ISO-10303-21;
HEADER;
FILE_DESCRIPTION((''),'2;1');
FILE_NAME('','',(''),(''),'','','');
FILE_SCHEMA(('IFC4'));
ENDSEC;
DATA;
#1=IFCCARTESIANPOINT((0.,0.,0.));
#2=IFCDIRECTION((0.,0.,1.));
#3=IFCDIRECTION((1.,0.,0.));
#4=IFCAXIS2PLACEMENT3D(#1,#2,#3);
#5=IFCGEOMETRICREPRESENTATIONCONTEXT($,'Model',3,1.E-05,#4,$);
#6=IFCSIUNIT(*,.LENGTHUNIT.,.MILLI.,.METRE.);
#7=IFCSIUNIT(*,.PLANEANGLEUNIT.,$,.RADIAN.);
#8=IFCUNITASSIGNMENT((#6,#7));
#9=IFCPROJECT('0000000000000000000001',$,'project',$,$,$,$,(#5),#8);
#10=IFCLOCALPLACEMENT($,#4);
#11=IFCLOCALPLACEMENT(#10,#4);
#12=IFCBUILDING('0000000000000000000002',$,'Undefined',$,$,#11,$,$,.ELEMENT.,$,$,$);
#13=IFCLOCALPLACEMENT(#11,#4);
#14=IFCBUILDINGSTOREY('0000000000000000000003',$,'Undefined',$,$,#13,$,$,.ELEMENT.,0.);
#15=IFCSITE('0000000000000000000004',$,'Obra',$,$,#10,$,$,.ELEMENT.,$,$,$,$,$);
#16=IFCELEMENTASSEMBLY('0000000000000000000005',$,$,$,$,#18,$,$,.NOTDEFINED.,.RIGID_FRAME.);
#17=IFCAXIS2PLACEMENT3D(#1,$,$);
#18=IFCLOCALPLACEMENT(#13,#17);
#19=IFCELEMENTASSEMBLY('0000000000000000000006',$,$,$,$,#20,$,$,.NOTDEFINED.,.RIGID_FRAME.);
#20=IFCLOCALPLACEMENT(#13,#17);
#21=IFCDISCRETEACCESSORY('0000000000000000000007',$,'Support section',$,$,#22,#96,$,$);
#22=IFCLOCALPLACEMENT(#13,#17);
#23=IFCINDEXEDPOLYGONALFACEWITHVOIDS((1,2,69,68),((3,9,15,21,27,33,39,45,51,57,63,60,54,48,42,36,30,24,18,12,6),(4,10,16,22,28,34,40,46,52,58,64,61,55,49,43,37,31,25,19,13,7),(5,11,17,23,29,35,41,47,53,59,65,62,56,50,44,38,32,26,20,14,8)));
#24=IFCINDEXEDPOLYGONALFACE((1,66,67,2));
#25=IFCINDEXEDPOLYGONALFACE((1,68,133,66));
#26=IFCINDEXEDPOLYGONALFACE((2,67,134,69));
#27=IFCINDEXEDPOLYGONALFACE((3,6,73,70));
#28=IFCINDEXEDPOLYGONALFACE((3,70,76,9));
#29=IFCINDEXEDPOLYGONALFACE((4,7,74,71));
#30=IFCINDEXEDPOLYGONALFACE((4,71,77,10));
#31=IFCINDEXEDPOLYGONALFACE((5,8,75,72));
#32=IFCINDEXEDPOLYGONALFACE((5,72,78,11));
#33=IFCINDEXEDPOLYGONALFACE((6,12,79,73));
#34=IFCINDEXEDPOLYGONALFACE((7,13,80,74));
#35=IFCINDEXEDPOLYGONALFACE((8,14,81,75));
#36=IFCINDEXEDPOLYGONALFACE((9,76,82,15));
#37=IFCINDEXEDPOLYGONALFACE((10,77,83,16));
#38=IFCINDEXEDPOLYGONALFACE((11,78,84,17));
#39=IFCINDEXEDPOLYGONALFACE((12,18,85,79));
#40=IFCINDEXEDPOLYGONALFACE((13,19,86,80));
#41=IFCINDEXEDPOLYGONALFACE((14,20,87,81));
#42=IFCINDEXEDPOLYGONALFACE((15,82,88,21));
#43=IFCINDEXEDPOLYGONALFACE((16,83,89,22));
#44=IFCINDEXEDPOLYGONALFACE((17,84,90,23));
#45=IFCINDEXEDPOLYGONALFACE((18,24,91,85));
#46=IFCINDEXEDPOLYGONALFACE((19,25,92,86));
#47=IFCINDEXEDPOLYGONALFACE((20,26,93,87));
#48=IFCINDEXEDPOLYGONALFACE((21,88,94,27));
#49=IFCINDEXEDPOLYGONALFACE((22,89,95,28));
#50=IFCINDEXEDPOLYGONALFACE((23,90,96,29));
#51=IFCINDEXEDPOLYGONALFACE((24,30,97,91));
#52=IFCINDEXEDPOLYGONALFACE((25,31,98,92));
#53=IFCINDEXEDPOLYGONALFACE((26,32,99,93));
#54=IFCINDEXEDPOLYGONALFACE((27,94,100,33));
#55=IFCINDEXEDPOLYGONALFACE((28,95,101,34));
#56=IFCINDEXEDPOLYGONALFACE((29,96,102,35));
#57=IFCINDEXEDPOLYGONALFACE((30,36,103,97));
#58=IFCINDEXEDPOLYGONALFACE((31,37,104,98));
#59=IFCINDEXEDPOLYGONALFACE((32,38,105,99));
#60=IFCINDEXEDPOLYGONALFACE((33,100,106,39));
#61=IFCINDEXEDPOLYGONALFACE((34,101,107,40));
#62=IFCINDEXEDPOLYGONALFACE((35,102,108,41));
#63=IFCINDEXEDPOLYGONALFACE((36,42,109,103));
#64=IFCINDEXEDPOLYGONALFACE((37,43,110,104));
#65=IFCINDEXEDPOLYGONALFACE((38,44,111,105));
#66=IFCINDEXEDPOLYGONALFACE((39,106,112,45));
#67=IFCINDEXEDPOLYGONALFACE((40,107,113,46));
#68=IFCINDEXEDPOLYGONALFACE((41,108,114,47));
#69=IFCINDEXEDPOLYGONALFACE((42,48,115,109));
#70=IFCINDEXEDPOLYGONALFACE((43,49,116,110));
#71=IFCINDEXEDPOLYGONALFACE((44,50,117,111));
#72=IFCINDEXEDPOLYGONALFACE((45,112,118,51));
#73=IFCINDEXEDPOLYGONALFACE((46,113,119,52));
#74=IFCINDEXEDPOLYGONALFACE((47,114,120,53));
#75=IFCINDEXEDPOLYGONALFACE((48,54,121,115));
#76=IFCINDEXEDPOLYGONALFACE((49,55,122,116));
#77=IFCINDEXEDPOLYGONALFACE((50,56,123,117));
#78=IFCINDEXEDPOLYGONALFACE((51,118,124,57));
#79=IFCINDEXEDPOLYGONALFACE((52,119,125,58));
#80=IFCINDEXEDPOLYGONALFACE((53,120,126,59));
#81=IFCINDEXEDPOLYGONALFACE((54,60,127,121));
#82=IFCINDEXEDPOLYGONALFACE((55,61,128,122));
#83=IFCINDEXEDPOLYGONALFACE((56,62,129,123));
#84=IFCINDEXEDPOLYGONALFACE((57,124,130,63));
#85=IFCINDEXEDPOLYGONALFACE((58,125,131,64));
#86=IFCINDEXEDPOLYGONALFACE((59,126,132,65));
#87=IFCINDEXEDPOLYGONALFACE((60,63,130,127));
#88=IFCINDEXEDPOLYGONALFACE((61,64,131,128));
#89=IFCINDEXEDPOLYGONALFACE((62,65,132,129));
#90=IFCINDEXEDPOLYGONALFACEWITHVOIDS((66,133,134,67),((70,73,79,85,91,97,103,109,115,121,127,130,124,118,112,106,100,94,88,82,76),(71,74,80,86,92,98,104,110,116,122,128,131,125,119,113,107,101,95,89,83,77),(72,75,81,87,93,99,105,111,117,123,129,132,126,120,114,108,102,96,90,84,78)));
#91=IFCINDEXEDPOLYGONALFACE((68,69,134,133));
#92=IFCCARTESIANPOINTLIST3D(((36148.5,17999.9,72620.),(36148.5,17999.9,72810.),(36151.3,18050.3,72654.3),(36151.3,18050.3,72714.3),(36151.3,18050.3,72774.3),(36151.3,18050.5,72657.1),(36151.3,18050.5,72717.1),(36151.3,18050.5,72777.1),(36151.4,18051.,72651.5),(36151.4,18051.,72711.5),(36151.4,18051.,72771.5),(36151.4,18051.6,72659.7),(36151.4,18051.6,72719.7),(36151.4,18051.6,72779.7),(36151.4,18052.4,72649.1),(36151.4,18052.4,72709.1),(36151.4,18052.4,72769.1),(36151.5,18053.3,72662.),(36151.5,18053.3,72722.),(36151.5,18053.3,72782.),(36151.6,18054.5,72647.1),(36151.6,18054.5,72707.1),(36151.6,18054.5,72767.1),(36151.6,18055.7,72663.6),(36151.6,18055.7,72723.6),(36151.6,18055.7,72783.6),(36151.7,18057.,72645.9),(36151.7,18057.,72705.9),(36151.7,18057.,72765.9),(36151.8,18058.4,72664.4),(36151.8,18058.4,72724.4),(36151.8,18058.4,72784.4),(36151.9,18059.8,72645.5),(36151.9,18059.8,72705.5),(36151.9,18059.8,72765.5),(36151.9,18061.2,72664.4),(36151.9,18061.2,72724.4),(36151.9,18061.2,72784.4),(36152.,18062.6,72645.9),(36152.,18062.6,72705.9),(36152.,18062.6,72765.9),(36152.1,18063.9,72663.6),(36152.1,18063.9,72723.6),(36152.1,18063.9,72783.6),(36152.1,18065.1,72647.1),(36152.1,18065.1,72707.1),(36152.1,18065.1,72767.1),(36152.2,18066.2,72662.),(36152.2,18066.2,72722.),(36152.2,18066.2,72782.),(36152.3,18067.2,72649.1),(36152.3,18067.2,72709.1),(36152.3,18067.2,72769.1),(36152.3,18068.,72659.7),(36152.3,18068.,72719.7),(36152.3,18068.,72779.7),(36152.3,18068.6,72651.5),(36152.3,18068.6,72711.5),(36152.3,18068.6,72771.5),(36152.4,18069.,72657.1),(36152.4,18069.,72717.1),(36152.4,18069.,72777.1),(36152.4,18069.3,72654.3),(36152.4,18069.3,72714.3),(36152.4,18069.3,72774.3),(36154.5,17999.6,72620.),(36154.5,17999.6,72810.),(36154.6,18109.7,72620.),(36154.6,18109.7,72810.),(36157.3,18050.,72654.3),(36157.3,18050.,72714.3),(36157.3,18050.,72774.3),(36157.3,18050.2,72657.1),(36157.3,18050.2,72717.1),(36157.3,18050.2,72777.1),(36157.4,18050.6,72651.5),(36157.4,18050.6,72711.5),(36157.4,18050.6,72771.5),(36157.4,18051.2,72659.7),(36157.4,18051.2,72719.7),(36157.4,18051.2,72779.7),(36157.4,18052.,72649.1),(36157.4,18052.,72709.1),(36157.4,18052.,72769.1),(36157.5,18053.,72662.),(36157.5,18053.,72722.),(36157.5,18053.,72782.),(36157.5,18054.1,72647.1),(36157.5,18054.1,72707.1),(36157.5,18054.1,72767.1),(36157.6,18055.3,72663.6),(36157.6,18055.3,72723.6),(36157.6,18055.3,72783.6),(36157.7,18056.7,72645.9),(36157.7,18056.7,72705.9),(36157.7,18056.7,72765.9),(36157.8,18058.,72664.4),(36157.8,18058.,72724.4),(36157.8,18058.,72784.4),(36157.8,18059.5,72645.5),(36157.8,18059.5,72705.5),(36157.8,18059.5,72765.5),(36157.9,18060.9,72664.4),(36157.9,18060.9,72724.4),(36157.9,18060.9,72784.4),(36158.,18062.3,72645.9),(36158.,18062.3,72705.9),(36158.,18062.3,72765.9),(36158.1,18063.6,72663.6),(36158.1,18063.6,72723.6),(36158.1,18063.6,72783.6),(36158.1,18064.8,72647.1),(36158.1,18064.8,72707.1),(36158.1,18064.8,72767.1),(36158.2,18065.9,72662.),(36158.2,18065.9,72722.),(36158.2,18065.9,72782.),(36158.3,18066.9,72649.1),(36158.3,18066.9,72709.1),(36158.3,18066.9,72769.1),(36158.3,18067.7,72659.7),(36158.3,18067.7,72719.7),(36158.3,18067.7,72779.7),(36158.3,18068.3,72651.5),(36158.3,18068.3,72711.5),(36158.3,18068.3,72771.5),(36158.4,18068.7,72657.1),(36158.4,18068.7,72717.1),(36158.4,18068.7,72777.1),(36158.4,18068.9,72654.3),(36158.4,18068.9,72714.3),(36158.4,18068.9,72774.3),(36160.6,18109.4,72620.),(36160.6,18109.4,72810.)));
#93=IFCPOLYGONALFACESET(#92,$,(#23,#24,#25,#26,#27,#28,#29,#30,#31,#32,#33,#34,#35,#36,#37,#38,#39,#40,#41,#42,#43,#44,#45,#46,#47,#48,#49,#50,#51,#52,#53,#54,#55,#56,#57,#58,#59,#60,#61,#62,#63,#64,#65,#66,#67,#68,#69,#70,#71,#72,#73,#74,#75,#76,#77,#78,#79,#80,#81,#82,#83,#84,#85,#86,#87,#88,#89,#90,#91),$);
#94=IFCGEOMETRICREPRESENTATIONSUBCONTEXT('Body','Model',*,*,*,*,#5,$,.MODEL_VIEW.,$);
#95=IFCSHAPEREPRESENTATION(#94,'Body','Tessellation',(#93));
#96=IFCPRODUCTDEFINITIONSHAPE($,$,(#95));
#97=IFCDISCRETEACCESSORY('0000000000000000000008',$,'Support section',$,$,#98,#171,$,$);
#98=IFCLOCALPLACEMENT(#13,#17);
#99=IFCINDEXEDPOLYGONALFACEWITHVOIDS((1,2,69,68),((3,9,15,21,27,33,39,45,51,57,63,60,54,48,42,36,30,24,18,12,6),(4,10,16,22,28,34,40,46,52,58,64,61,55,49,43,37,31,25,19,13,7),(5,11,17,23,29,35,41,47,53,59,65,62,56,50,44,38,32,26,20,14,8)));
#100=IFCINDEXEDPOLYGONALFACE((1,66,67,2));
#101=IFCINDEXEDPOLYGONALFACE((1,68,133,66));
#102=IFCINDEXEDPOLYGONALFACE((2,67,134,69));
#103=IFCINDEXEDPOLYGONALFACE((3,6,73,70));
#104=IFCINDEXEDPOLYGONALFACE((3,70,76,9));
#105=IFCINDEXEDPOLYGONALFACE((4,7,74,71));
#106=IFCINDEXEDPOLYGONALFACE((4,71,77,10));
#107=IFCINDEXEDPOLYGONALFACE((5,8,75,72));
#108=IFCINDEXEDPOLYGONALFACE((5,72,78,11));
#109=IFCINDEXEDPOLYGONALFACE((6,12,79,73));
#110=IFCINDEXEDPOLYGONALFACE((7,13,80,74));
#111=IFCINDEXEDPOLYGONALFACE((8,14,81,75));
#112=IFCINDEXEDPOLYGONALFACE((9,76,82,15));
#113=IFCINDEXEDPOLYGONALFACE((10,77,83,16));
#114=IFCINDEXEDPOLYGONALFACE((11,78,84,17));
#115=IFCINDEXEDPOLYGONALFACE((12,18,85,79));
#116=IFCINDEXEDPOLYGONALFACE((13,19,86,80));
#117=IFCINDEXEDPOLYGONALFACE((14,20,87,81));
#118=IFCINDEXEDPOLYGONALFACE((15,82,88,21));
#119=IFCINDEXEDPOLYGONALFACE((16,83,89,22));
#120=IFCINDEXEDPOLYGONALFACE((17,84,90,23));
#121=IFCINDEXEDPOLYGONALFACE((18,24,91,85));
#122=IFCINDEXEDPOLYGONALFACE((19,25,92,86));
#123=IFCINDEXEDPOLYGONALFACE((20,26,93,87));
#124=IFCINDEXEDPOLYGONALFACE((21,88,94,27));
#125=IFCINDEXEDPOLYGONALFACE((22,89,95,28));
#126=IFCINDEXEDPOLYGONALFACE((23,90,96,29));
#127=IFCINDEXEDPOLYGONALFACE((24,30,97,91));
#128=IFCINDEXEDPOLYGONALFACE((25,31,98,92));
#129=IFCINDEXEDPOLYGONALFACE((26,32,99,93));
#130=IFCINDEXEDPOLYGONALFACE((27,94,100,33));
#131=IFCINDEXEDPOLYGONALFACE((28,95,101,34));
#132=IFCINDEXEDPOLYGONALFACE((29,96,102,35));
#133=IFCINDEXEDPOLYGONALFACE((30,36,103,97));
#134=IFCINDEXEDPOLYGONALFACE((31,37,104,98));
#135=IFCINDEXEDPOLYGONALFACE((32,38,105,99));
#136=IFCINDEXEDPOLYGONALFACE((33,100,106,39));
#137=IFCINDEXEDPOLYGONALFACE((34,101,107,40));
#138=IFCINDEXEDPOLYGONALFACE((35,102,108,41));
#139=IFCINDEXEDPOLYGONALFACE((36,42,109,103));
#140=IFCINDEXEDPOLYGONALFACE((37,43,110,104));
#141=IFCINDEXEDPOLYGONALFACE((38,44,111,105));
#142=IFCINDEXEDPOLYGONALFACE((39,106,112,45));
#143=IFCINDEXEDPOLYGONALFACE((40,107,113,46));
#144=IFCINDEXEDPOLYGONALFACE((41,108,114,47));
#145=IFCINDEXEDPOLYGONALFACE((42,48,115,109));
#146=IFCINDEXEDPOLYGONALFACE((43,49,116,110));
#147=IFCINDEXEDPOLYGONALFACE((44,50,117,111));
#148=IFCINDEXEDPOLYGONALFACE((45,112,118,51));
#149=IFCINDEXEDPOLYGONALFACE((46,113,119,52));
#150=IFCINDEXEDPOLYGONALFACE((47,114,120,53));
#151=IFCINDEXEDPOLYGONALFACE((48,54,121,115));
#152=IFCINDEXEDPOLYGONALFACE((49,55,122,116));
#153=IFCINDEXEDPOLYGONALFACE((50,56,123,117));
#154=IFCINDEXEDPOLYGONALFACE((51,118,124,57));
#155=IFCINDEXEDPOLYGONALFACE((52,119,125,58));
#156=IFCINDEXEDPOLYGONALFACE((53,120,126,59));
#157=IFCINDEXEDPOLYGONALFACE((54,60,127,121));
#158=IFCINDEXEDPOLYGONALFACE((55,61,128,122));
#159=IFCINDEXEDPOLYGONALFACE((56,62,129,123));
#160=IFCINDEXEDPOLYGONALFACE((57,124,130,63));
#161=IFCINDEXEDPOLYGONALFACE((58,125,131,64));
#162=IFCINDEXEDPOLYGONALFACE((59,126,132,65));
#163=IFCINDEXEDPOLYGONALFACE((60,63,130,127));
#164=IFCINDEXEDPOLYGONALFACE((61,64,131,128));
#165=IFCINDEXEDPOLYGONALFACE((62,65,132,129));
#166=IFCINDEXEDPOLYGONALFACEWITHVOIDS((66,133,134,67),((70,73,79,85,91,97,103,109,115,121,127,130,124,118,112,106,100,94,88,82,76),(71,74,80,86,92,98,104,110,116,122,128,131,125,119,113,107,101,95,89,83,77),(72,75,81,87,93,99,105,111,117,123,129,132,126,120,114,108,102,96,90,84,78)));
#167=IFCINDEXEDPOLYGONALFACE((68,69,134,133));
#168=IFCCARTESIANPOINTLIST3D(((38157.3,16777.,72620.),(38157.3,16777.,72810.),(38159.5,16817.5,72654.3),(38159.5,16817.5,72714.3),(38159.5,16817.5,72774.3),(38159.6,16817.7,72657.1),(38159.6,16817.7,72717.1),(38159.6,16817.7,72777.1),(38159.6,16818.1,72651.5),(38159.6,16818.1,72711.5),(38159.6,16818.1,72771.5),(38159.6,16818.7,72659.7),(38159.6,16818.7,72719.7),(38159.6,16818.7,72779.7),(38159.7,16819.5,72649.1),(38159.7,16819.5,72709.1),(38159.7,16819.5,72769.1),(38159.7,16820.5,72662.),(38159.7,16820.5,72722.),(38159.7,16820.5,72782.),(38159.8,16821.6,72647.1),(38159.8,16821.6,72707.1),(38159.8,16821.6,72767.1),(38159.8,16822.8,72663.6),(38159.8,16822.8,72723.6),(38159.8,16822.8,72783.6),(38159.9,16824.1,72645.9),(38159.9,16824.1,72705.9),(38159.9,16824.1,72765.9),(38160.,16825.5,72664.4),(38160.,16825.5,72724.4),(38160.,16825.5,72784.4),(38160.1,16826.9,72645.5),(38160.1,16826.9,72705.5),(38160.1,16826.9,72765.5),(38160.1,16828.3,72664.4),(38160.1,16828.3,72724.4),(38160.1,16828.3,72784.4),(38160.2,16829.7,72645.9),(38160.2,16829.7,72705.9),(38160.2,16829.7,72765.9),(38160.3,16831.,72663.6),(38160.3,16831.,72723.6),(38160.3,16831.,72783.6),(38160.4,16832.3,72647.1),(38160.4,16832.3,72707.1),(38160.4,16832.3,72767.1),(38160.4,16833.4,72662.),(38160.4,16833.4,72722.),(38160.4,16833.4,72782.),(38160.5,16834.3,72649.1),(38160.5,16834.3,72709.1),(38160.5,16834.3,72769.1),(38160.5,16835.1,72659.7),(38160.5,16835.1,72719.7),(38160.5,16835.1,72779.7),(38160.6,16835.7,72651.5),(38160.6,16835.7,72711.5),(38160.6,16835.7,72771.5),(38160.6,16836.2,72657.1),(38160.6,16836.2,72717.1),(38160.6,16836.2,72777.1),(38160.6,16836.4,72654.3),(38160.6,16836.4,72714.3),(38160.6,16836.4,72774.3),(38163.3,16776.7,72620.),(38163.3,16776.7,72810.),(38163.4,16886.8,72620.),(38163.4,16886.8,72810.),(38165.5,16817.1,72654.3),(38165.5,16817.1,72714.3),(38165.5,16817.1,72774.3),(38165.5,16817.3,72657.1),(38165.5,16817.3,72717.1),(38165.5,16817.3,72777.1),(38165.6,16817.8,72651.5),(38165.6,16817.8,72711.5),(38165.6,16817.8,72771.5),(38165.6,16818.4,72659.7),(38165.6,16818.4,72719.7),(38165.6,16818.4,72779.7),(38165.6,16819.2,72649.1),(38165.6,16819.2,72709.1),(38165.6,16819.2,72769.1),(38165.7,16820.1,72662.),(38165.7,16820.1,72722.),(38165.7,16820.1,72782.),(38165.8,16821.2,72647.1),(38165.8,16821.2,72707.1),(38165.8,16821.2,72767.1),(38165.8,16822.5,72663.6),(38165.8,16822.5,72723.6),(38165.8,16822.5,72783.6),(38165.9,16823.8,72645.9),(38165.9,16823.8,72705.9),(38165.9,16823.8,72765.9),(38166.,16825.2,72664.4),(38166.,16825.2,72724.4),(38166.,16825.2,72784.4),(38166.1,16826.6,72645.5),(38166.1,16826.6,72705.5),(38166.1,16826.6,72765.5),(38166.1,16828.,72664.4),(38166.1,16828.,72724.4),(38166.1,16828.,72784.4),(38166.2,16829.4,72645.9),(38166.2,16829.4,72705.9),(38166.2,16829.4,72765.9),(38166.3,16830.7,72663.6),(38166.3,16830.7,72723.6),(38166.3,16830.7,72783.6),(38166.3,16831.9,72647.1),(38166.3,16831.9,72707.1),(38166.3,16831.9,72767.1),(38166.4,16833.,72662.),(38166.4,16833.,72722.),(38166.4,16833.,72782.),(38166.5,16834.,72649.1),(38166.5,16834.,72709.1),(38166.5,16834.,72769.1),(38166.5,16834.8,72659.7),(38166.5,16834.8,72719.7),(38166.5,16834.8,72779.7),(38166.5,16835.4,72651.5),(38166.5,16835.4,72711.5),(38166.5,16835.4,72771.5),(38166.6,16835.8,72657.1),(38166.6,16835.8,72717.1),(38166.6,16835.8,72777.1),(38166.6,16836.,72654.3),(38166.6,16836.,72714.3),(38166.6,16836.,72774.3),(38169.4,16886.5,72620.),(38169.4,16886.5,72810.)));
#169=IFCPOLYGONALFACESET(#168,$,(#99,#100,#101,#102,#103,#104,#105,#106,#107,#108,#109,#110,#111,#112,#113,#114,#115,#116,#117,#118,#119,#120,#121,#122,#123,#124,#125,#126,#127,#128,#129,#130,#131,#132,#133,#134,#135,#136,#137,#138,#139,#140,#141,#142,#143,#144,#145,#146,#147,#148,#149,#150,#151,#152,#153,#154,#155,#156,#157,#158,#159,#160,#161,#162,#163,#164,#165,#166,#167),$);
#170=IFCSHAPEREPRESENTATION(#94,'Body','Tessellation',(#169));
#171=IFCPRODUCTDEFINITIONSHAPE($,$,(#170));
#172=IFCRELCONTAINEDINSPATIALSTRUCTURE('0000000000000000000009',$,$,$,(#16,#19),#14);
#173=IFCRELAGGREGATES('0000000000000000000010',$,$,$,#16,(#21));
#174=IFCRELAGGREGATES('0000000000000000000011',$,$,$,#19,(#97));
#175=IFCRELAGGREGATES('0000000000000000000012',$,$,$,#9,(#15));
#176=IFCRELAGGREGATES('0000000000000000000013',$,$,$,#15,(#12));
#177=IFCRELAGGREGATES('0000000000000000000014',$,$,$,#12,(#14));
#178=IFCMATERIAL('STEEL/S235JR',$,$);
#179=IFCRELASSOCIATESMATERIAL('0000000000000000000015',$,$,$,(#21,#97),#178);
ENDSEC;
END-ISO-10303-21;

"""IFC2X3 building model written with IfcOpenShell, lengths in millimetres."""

from ifc_helpers import new_model, si_unit, frame, origin_with_axes, origin_2d_with_axis, place, context, subcontext, project, spatial, rectangle, circle, extrude, source, transform, mapped, material, element, aggregate, save


model = new_model("IFC2X3")

# Units and contexts
model_context = context("Model", 3, precision=1e-05, world=origin_with_axes())
body_context = subcontext(model_context, "Body", "Model", "MODEL_VIEW")
ifc_project = project(units=[si_unit("LENGTHUNIT", "METRE", prefix="MILLI"), si_unit("PLANEANGLEUNIT", "RADIAN")], contexts=[model_context])

# Site, building, storey
site_placement = place(None, origin_with_axes())
site = spatial("IfcSite", under=ifc_project, at=site_placement, Name="Obra", CompositionType="ELEMENT")
building_placement = place(site_placement, origin_with_axes())
building = spatial("IfcBuilding", under=site, at=building_placement, Name="Undefined", CompositionType="ELEMENT")
storey_placement = place(building_placement, origin_with_axes())
storey = spatial("IfcBuildingStorey", under=building, at=storey_placement, Name="Undefined", CompositionType="ELEMENT", Elevation=0.0)

# Element assemblies
assembly_1_placement = place(storey_placement, origin_with_axes())
assembly_1 = element("IfcElementAssembly", 1, at=assembly_1_placement, inside=storey, AssemblyPlace="NOTDEFINED", PredefinedType="RIGID_FRAME")
ifc_material = material(Name="STEEL/S235JR")
assembly_2_placement = place(storey_placement, origin_with_axes())
assembly_2 = element("IfcElementAssembly", 2, at=assembly_2_placement, inside=storey, AssemblyPlace="NOTDEFINED", PredefinedType="RIGID_FRAME")

# Discrete accessories, openings
discrete_accessory_1_placement = place(assembly_1_placement, frame((36154.6, 18054.6, 72620.0), z_axis=(0.0, 0.0, 1.0), x_axis=(-0.055268, -0.998472, 0.0)))
discrete_accessory_1 = element("IfcDiscreteAccessory", 3, at=discrete_accessory_1_placement, material=ifc_material, Name="Support section", context=body_context, shape_type="SweptSolid", body=[
    extrude(rectangle(XDim=6.0, YDim=110.0, at=origin_2d_with_axis()), frame((0.0, 0.0, 190.0), z_axis=(0.0, 0.0, -1.0), x_axis=(0.0, 1.0, 0.0)), (0.0, 0.0, 1.0), 190.0),
])
shared_shape_1 = source(origin_with_axes(), body_context, "Body", "SweptSolid", [
    extrude(circle(Radius=9.5, at=origin_2d_with_axis()), frame((0.0, -9.2, 0.0), z_axis=(0.0, 1.0, 0.0), x_axis=(1.0, 0.0, 0.0)), (0.0, 0.0, 1.0), 6.2),
])
opening_1_placement = place(assembly_1_placement, frame((36146.0, 18010.0, 72835.0), z_axis=(0.055268, 0.998472, 0.0), x_axis=(0.0, 0.0, -1.0)))
element("IfcOpeningElement", 4, at=opening_1_placement, cuts=discrete_accessory_1, ObjectType="Opening", context=body_context, shape_type="MappedRepresentation", body=[
    mapped(shared_shape_1, transform((60.0, 0.0, 50.0))),
    mapped(shared_shape_1, transform((120.0, 0.0, 50.0))),
    mapped(shared_shape_1, transform((180.0, 0.0, 50.0))),
])
aggregate(assembly_1, [discrete_accessory_1])
discrete_accessory_2_placement = place(assembly_2_placement, frame((38163.3, 16831.7, 72620.0), z_axis=(0.0, 0.0, 1.0), x_axis=(0.055268, 0.998472, 0.0)))
discrete_accessory_2 = element("IfcDiscreteAccessory", 5, at=discrete_accessory_2_placement, material=ifc_material, Name="Support section", context=body_context, shape_type="SweptSolid", body=[
    extrude(rectangle(XDim=6.0, YDim=110.0, at=origin_2d_with_axis()), frame((0.0, 0.0, 190.0), z_axis=(0.0, 0.0, -1.0), x_axis=(0.0, 1.0, 0.0)), (0.0, 0.0, 1.0), 190.0),
])
opening_2_placement = place(assembly_2_placement, frame((38171.9, 16876.3, 72835.0), z_axis=(-0.055268, -0.998472, 0.0), x_axis=(0.0, 0.0, -1.0)))
element("IfcOpeningElement", 6, at=opening_2_placement, cuts=discrete_accessory_2, ObjectType="Opening", context=body_context, shape_type="MappedRepresentation", body=[
    mapped(shared_shape_1, transform((60.0, 0.0, 50.0))),
    mapped(shared_shape_1, transform((120.0, 0.0, 50.0))),
    mapped(shared_shape_1, transform((180.0, 0.0, 50.0))),
])
aggregate(assembly_2, [discrete_accessory_2])

save(model, "model.ifc")
